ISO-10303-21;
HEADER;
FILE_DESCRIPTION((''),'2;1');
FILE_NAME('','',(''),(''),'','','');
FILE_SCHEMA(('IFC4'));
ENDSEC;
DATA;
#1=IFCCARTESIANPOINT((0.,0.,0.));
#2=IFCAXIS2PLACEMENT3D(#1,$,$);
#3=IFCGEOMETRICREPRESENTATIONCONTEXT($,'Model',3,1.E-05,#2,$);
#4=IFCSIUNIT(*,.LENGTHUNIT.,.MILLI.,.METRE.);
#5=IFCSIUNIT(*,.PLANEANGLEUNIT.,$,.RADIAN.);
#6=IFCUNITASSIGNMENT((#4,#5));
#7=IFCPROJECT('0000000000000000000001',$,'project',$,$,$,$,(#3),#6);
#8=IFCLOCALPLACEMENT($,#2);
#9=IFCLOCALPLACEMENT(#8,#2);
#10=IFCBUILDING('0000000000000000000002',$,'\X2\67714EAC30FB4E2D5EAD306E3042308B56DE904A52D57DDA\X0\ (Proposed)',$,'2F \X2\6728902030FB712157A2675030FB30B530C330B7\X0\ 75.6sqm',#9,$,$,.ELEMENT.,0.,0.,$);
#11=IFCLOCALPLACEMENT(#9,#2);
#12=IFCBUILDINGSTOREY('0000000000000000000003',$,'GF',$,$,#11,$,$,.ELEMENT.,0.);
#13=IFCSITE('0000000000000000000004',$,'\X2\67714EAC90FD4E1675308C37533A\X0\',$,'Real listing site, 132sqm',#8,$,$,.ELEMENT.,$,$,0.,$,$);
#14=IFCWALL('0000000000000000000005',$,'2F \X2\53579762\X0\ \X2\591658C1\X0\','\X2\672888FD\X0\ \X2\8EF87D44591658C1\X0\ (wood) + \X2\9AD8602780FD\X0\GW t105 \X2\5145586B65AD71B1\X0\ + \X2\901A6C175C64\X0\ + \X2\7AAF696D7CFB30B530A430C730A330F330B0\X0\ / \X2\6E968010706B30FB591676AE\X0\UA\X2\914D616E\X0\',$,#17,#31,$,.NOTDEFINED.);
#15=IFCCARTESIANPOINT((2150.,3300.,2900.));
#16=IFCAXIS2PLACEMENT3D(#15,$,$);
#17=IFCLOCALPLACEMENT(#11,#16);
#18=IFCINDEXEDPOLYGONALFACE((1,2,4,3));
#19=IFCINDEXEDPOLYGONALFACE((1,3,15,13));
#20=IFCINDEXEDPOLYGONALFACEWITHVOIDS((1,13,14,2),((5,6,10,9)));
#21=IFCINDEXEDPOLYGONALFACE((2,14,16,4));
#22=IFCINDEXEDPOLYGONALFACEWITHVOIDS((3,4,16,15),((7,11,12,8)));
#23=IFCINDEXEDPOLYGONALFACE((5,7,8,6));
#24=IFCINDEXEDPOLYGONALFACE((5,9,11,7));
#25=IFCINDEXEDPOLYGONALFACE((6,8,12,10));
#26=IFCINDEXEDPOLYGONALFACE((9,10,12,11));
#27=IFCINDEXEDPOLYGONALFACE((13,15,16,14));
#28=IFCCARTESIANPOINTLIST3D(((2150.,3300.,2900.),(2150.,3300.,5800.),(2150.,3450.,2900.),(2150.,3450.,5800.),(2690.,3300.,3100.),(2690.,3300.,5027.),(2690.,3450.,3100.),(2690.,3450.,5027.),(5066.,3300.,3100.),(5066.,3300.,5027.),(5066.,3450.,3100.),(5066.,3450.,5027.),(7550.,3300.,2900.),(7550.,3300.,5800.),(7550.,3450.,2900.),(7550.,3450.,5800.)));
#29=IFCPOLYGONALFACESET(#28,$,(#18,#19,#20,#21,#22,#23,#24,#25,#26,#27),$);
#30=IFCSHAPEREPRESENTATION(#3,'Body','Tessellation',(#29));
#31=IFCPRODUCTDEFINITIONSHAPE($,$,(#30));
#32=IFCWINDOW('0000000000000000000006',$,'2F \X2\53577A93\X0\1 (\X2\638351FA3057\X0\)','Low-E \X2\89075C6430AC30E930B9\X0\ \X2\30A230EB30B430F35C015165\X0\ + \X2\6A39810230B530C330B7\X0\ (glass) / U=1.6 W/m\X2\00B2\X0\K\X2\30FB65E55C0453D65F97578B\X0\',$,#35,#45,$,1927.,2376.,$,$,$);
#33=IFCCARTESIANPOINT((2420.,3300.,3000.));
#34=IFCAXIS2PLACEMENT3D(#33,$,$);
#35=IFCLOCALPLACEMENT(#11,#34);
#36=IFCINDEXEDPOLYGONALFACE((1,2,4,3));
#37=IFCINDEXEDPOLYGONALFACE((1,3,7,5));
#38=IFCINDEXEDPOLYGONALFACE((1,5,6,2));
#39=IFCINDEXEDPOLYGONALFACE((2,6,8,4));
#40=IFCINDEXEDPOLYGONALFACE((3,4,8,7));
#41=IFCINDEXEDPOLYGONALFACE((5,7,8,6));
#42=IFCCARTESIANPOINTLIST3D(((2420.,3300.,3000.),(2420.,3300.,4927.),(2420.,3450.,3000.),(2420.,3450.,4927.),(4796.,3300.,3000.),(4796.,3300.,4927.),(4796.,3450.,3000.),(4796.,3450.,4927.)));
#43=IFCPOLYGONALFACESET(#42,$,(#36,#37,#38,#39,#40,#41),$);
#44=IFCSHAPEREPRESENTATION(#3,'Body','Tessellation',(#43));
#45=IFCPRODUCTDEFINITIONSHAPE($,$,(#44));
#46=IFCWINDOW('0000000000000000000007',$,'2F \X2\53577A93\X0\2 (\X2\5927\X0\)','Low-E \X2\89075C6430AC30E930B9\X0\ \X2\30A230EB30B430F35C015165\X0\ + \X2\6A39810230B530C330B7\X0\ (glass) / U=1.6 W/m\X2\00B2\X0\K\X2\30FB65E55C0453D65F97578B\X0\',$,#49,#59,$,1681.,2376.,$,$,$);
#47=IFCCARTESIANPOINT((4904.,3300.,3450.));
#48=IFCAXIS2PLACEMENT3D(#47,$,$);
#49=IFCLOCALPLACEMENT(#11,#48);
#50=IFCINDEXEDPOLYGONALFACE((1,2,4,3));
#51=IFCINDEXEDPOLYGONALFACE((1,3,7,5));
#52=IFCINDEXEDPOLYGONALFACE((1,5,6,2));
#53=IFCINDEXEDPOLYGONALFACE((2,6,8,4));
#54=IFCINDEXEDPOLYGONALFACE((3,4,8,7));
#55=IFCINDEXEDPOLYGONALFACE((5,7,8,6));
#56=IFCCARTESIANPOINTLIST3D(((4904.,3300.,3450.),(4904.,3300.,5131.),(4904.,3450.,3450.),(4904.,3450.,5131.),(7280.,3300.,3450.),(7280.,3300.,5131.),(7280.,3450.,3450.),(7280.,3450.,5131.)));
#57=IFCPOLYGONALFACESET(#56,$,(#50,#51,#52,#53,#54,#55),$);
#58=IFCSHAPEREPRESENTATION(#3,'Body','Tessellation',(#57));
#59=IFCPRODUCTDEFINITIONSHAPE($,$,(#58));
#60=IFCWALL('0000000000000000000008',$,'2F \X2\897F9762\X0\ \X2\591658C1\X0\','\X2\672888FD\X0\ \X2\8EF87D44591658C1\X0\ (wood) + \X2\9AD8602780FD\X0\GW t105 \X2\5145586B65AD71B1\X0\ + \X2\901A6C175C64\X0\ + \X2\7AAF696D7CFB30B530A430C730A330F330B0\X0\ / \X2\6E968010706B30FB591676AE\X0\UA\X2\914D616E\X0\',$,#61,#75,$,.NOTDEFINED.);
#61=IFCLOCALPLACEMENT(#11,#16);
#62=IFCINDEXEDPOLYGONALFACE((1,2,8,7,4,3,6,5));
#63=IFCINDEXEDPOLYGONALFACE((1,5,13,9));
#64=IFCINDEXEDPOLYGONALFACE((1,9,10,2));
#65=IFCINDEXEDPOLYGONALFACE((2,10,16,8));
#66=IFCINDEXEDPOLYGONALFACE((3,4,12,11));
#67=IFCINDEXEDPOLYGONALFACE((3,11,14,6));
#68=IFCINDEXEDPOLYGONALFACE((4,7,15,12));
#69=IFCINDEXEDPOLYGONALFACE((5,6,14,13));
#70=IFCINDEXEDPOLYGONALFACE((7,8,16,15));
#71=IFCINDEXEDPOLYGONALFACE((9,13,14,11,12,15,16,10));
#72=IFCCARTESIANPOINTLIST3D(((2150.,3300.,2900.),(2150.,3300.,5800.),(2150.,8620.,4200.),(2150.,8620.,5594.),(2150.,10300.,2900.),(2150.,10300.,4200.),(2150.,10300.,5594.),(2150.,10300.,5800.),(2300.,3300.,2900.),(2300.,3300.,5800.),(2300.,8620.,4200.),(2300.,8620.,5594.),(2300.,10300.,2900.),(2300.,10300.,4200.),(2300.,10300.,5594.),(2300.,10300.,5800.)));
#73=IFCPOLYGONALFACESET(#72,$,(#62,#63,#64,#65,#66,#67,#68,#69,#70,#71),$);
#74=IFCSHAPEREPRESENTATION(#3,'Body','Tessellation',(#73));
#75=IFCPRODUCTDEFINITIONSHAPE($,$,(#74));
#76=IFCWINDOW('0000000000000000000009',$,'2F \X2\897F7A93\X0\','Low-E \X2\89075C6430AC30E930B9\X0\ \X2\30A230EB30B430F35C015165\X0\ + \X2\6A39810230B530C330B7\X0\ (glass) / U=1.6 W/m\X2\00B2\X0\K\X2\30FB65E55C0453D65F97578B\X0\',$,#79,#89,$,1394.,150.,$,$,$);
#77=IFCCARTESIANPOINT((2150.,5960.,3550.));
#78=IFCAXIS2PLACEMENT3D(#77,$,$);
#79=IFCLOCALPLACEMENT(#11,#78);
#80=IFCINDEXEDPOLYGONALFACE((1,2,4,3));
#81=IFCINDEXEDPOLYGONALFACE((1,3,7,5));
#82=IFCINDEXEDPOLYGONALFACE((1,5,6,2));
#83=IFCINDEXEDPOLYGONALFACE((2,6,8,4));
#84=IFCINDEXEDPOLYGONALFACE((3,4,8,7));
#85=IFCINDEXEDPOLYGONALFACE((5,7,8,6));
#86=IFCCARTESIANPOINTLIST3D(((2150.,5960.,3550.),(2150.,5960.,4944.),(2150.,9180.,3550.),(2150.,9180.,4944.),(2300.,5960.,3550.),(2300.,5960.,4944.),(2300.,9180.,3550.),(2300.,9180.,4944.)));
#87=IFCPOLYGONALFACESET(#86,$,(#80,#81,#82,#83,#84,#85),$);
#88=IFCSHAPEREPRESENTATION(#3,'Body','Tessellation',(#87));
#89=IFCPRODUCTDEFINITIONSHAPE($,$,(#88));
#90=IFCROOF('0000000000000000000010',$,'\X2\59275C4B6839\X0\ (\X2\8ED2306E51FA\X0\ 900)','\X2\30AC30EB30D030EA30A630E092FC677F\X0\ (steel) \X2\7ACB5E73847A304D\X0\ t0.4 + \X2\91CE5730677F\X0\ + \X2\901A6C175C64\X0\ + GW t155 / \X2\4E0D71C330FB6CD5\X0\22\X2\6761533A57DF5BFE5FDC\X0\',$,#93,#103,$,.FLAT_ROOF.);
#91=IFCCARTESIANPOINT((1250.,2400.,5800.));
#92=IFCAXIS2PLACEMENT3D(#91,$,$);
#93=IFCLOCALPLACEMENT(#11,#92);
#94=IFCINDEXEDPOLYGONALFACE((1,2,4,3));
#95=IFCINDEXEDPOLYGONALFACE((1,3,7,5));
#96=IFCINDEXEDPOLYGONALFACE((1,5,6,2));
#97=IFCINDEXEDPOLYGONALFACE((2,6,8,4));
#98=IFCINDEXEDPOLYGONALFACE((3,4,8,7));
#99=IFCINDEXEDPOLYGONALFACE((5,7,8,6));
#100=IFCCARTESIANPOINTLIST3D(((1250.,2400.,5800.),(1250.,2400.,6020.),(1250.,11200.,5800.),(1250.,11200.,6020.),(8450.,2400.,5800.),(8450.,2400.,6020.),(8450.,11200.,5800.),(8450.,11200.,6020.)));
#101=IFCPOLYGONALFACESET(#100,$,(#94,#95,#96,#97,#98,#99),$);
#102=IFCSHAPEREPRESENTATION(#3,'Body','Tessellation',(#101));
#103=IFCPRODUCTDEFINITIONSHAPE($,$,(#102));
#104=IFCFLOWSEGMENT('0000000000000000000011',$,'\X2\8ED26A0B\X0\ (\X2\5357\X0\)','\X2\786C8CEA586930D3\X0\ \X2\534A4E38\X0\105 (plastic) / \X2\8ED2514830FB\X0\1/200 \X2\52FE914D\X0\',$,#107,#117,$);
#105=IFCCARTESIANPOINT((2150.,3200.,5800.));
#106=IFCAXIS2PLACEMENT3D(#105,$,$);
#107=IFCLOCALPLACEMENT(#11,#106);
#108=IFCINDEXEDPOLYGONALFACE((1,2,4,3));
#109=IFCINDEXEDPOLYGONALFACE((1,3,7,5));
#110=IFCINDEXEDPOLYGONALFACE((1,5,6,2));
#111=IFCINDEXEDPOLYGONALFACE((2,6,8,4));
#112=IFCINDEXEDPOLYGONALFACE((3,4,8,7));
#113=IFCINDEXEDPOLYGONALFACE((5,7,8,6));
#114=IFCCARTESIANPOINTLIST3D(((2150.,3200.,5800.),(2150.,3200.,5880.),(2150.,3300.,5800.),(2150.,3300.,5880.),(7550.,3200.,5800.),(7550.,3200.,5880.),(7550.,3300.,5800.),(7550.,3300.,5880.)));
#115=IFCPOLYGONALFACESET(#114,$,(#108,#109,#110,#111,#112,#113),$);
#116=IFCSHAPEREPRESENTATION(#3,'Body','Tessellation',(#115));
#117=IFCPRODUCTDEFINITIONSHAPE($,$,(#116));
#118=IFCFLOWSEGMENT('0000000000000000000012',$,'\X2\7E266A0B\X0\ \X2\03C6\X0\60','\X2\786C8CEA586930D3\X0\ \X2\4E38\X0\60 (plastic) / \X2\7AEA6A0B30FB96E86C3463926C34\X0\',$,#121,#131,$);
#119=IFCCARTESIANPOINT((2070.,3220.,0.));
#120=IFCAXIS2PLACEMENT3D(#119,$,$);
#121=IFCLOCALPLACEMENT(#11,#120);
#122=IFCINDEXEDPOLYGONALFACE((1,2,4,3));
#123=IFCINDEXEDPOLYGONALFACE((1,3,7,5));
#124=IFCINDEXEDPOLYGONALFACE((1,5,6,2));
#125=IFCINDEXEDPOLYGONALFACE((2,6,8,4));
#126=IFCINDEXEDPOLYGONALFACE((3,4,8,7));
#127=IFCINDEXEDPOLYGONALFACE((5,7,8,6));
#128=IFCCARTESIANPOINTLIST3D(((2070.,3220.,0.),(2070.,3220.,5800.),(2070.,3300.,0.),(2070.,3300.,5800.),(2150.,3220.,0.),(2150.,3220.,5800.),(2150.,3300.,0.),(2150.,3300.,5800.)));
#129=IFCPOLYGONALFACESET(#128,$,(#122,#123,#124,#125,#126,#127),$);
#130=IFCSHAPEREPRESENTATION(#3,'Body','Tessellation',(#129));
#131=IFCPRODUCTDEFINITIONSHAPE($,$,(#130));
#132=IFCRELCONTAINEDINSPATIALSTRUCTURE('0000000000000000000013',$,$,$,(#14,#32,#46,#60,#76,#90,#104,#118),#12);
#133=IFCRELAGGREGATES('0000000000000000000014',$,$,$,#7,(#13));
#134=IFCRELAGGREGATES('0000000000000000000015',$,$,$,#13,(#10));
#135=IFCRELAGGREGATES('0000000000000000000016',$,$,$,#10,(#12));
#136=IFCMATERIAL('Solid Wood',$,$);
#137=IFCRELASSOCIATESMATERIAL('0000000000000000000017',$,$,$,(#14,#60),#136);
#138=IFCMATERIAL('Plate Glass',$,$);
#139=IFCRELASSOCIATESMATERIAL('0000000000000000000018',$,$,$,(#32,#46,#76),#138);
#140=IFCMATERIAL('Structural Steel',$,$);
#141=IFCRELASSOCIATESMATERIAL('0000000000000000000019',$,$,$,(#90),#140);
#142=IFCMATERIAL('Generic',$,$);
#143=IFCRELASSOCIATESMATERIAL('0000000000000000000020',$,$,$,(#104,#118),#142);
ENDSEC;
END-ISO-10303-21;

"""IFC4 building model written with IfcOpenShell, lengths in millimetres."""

from ifc_helpers import new_model, si_unit, frame, frame_2d, origin, place, context, project, spatial, rectangle, extrude, material, element, fill, save


model = new_model("IFC4")

# Units and contexts
model_context = context("Model", 3, precision=1e-05, world=origin())
ifc_project = project(units=[si_unit("LENGTHUNIT", "METRE", prefix="MILLI"), si_unit("PLANEANGLEUNIT", "RADIAN")], contexts=[model_context])

# Site, building, storey
site_placement = place(None, origin())
site = spatial("IfcSite", under=ifc_project, at=site_placement, Name="東京都世田谷区", ObjectType="Real listing site, 132sqm", CompositionType="ELEMENT", RefElevation=0.0)
building_placement = place(site_placement, origin())
building = spatial("IfcBuilding", under=site, at=building_placement, Name="東京・中庭のある回遊動線 (Proposed)", ObjectType="2F 木造・無垢材・サッシ 75.6sqm", CompositionType="ELEMENT", ElevationOfRefHeight=0.0, ElevationOfTerrain=0.0)
storey_placement = place(building_placement, origin())
storey = spatial("IfcBuildingStorey", under=building, at=storey_placement, Name="GF", CompositionType="ELEMENT", Elevation=0.0)

# Shared definitions
ifc_material_1 = material(Name="Solid Wood")

# Shared definitions
ifc_material_2 = material(Name="Plate Glass")

# Wall, openings, windows
wall_1_placement = place(storey_placement, frame((2150.0, 3300.0, 2900.0)))
wall_1 = element("IfcWall", 1, at=wall_1_placement, inside=storey, material=ifc_material_1, Name="2F 南面 外壁", Description="木製 軸組外壁 (wood) + 高性能GW t105 充填断熱 + 通気層 + 窯業系サイディング / 準耐火・外皮UA配慮", PredefinedType="NOTDEFINED", context=model_context, shape_type="SweptSolid", body=[
    extrude(rectangle(XDim=5400.0, YDim=150.0, at=frame_2d((2700.0, 75.0))), frame((2150.0, 3300.0, 2900.0)), (0.0, 0.0, 1.0), 2900.0),
])
opening_1_placement = place(storey_placement, frame((2420.0, 3300.0, 3000.0)))
opening_1 = element("IfcOpeningElement", 2, at=opening_1_placement, cuts=wall_1, PredefinedType="NOTDEFINED", context=model_context, shape_type="SweptSolid", body=[
    extrude(rectangle(XDim=2376.0, YDim=150.0, at=frame_2d((1188.0, 75.0))), frame((2420.0, 3300.0, 3000.0)), (0.0, 0.0, 1.0), 1927.0),
])
opening_2_placement = place(storey_placement, frame((4904.0, 3300.0, 3450.0)))
opening_2 = element("IfcOpeningElement", 3, at=opening_2_placement, cuts=wall_1, PredefinedType="NOTDEFINED", context=model_context, shape_type="SweptSolid", body=[
    extrude(rectangle(XDim=2376.0, YDim=150.0, at=frame_2d((1188.0, 75.0))), frame((4904.0, 3300.0, 3450.0)), (0.0, 0.0, 1.0), 1681.0),
])
window_1_placement = place(storey_placement, frame((2420.0, 3300.0, 3000.0)))
window_1 = element("IfcWindow", 4, at=window_1_placement, inside=storey, material=ifc_material_2, Name="2F 南窓1 (掃出し)", Description="Low-E 複層ガラス アルゴン封入 + 樹脂サッシ (glass) / U=1.6 W/m²K・日射取得型", OverallHeight=1927.0, OverallWidth=2376.0, context=model_context, shape_type="SweptSolid", body=[
    extrude(rectangle(XDim=2376.0, YDim=150.0, at=frame_2d((1188.0, 75.0))), frame((2420.0, 3300.0, 3000.0)), (0.0, 0.0, 1.0), 1927.0),
])
fill(opening_1, window_1)
window_2_placement = place(storey_placement, frame((4904.0, 3300.0, 3450.0)))
window_2 = element("IfcWindow", 5, at=window_2_placement, inside=storey, material=ifc_material_2, Name="2F 南窓2 (大)", Description="Low-E 複層ガラス アルゴン封入 + 樹脂サッシ (glass) / U=1.6 W/m²K・日射取得型", OverallHeight=1681.0, OverallWidth=2376.0, context=model_context, shape_type="SweptSolid", body=[
    extrude(rectangle(XDim=2376.0, YDim=150.0, at=frame_2d((1188.0, 75.0))), frame((4904.0, 3300.0, 3450.0)), (0.0, 0.0, 1.0), 1681.0),
])
fill(opening_2, window_2)

# Wall, opening, window
wall_2_placement = place(storey_placement, frame((2150.0, 3300.0, 2900.0)))
wall_2 = element("IfcWall", 6, at=wall_2_placement, inside=storey, material=ifc_material_1, Name="2F 西面 外壁", Description="木製 軸組外壁 (wood) + 高性能GW t105 充填断熱 + 通気層 + 窯業系サイディング / 準耐火・外皮UA配慮", PredefinedType="NOTDEFINED", context=model_context, shape_type="SweptSolid", body=[
    extrude(rectangle(XDim=150.0, YDim=7000.0, at=frame_2d((75.0, 3500.0))), frame((2150.0, 3300.0, 2900.0)), (0.0, 0.0, 1.0), 2900.0),
])
opening_3_placement = place(storey_placement, frame((2150.0, 5960.0, 3550.0)))
opening_3 = element("IfcOpeningElement", 7, at=opening_3_placement, cuts=wall_2, PredefinedType="NOTDEFINED", context=model_context, shape_type="SweptSolid", body=[
    extrude(rectangle(XDim=150.0, YDim=3220.0, at=frame_2d((75.0, 1610.0))), frame((2150.0, 5960.0, 3550.0)), (0.0, 0.0, 1.0), 1394.0),
])
window_3_placement = place(storey_placement, frame((2150.0, 5960.0, 3550.0)))
window_3 = element("IfcWindow", 8, at=window_3_placement, inside=storey, material=ifc_material_2, Name="2F 西窓", Description="Low-E 複層ガラス アルゴン封入 + 樹脂サッシ (glass) / U=1.6 W/m²K・日射取得型", OverallHeight=1394.0, OverallWidth=150.0, context=model_context, shape_type="SweptSolid", body=[
    extrude(rectangle(XDim=150.0, YDim=3220.0, at=frame_2d((75.0, 1610.0))), frame((2150.0, 5960.0, 3550.0)), (0.0, 0.0, 1.0), 1394.0),
])
fill(opening_3, window_3)

# Roof
ifc_material_3 = material(Name="Structural Steel")
roof_placement = place(storey_placement, frame((1250.0, 2400.0, 5800.0)))
element("IfcRoof", 9, at=roof_placement, inside=storey, material=ifc_material_3, Name="大屋根 (軒の出 900)", Description="ガルバリウム鋼板 (steel) 立平葺き t0.4 + 野地板 + 通気層 + GW t155 / 不燃・法22条区域対応", PredefinedType="FLAT_ROOF", context=model_context, shape_type="SweptSolid", body=[
    extrude(rectangle(XDim=7200.0, YDim=8800.0, at=frame_2d((3600.0, 4400.0))), frame((1250.0, 2400.0, 5800.0)), (0.0, 0.0, 1.0), 220.0),
])

# Flow segments
ifc_material_4 = material(Name="Generic")
flow_segment_1_placement = place(storey_placement, frame((2150.0, 3200.0, 5800.0)))
element("IfcFlowSegment", 10, at=flow_segment_1_placement, inside=storey, material=ifc_material_4, Name="軒樋 (南)", Description="硬質塩ビ 半丸105 (plastic) / 軒先・1/200 勾配", context=model_context, shape_type="SweptSolid", body=[
    extrude(rectangle(XDim=5400.0, YDim=100.0, at=frame_2d((2700.0, 50.0))), frame((2150.0, 3200.0, 5800.0)), (0.0, 0.0, 1.0), 80.0),
])
flow_segment_2_placement = place(storey_placement, frame((2070.0, 3220.0, 0.0)))
element("IfcFlowSegment", 11, at=flow_segment_2_placement, inside=storey, material=ifc_material_4, Name="縦樋 φ60", Description="硬質塩ビ 丸60 (plastic) / 竪樋・雨水排水", context=model_context, shape_type="SweptSolid", body=[
    extrude(rectangle(XDim=80.0, YDim=80.0, at=frame_2d((40.0, 40.0))), frame((2070.0, 3220.0, 0.0)), (0.0, 0.0, 1.0), 5800.0),
])

save(model, "model.ifc")
